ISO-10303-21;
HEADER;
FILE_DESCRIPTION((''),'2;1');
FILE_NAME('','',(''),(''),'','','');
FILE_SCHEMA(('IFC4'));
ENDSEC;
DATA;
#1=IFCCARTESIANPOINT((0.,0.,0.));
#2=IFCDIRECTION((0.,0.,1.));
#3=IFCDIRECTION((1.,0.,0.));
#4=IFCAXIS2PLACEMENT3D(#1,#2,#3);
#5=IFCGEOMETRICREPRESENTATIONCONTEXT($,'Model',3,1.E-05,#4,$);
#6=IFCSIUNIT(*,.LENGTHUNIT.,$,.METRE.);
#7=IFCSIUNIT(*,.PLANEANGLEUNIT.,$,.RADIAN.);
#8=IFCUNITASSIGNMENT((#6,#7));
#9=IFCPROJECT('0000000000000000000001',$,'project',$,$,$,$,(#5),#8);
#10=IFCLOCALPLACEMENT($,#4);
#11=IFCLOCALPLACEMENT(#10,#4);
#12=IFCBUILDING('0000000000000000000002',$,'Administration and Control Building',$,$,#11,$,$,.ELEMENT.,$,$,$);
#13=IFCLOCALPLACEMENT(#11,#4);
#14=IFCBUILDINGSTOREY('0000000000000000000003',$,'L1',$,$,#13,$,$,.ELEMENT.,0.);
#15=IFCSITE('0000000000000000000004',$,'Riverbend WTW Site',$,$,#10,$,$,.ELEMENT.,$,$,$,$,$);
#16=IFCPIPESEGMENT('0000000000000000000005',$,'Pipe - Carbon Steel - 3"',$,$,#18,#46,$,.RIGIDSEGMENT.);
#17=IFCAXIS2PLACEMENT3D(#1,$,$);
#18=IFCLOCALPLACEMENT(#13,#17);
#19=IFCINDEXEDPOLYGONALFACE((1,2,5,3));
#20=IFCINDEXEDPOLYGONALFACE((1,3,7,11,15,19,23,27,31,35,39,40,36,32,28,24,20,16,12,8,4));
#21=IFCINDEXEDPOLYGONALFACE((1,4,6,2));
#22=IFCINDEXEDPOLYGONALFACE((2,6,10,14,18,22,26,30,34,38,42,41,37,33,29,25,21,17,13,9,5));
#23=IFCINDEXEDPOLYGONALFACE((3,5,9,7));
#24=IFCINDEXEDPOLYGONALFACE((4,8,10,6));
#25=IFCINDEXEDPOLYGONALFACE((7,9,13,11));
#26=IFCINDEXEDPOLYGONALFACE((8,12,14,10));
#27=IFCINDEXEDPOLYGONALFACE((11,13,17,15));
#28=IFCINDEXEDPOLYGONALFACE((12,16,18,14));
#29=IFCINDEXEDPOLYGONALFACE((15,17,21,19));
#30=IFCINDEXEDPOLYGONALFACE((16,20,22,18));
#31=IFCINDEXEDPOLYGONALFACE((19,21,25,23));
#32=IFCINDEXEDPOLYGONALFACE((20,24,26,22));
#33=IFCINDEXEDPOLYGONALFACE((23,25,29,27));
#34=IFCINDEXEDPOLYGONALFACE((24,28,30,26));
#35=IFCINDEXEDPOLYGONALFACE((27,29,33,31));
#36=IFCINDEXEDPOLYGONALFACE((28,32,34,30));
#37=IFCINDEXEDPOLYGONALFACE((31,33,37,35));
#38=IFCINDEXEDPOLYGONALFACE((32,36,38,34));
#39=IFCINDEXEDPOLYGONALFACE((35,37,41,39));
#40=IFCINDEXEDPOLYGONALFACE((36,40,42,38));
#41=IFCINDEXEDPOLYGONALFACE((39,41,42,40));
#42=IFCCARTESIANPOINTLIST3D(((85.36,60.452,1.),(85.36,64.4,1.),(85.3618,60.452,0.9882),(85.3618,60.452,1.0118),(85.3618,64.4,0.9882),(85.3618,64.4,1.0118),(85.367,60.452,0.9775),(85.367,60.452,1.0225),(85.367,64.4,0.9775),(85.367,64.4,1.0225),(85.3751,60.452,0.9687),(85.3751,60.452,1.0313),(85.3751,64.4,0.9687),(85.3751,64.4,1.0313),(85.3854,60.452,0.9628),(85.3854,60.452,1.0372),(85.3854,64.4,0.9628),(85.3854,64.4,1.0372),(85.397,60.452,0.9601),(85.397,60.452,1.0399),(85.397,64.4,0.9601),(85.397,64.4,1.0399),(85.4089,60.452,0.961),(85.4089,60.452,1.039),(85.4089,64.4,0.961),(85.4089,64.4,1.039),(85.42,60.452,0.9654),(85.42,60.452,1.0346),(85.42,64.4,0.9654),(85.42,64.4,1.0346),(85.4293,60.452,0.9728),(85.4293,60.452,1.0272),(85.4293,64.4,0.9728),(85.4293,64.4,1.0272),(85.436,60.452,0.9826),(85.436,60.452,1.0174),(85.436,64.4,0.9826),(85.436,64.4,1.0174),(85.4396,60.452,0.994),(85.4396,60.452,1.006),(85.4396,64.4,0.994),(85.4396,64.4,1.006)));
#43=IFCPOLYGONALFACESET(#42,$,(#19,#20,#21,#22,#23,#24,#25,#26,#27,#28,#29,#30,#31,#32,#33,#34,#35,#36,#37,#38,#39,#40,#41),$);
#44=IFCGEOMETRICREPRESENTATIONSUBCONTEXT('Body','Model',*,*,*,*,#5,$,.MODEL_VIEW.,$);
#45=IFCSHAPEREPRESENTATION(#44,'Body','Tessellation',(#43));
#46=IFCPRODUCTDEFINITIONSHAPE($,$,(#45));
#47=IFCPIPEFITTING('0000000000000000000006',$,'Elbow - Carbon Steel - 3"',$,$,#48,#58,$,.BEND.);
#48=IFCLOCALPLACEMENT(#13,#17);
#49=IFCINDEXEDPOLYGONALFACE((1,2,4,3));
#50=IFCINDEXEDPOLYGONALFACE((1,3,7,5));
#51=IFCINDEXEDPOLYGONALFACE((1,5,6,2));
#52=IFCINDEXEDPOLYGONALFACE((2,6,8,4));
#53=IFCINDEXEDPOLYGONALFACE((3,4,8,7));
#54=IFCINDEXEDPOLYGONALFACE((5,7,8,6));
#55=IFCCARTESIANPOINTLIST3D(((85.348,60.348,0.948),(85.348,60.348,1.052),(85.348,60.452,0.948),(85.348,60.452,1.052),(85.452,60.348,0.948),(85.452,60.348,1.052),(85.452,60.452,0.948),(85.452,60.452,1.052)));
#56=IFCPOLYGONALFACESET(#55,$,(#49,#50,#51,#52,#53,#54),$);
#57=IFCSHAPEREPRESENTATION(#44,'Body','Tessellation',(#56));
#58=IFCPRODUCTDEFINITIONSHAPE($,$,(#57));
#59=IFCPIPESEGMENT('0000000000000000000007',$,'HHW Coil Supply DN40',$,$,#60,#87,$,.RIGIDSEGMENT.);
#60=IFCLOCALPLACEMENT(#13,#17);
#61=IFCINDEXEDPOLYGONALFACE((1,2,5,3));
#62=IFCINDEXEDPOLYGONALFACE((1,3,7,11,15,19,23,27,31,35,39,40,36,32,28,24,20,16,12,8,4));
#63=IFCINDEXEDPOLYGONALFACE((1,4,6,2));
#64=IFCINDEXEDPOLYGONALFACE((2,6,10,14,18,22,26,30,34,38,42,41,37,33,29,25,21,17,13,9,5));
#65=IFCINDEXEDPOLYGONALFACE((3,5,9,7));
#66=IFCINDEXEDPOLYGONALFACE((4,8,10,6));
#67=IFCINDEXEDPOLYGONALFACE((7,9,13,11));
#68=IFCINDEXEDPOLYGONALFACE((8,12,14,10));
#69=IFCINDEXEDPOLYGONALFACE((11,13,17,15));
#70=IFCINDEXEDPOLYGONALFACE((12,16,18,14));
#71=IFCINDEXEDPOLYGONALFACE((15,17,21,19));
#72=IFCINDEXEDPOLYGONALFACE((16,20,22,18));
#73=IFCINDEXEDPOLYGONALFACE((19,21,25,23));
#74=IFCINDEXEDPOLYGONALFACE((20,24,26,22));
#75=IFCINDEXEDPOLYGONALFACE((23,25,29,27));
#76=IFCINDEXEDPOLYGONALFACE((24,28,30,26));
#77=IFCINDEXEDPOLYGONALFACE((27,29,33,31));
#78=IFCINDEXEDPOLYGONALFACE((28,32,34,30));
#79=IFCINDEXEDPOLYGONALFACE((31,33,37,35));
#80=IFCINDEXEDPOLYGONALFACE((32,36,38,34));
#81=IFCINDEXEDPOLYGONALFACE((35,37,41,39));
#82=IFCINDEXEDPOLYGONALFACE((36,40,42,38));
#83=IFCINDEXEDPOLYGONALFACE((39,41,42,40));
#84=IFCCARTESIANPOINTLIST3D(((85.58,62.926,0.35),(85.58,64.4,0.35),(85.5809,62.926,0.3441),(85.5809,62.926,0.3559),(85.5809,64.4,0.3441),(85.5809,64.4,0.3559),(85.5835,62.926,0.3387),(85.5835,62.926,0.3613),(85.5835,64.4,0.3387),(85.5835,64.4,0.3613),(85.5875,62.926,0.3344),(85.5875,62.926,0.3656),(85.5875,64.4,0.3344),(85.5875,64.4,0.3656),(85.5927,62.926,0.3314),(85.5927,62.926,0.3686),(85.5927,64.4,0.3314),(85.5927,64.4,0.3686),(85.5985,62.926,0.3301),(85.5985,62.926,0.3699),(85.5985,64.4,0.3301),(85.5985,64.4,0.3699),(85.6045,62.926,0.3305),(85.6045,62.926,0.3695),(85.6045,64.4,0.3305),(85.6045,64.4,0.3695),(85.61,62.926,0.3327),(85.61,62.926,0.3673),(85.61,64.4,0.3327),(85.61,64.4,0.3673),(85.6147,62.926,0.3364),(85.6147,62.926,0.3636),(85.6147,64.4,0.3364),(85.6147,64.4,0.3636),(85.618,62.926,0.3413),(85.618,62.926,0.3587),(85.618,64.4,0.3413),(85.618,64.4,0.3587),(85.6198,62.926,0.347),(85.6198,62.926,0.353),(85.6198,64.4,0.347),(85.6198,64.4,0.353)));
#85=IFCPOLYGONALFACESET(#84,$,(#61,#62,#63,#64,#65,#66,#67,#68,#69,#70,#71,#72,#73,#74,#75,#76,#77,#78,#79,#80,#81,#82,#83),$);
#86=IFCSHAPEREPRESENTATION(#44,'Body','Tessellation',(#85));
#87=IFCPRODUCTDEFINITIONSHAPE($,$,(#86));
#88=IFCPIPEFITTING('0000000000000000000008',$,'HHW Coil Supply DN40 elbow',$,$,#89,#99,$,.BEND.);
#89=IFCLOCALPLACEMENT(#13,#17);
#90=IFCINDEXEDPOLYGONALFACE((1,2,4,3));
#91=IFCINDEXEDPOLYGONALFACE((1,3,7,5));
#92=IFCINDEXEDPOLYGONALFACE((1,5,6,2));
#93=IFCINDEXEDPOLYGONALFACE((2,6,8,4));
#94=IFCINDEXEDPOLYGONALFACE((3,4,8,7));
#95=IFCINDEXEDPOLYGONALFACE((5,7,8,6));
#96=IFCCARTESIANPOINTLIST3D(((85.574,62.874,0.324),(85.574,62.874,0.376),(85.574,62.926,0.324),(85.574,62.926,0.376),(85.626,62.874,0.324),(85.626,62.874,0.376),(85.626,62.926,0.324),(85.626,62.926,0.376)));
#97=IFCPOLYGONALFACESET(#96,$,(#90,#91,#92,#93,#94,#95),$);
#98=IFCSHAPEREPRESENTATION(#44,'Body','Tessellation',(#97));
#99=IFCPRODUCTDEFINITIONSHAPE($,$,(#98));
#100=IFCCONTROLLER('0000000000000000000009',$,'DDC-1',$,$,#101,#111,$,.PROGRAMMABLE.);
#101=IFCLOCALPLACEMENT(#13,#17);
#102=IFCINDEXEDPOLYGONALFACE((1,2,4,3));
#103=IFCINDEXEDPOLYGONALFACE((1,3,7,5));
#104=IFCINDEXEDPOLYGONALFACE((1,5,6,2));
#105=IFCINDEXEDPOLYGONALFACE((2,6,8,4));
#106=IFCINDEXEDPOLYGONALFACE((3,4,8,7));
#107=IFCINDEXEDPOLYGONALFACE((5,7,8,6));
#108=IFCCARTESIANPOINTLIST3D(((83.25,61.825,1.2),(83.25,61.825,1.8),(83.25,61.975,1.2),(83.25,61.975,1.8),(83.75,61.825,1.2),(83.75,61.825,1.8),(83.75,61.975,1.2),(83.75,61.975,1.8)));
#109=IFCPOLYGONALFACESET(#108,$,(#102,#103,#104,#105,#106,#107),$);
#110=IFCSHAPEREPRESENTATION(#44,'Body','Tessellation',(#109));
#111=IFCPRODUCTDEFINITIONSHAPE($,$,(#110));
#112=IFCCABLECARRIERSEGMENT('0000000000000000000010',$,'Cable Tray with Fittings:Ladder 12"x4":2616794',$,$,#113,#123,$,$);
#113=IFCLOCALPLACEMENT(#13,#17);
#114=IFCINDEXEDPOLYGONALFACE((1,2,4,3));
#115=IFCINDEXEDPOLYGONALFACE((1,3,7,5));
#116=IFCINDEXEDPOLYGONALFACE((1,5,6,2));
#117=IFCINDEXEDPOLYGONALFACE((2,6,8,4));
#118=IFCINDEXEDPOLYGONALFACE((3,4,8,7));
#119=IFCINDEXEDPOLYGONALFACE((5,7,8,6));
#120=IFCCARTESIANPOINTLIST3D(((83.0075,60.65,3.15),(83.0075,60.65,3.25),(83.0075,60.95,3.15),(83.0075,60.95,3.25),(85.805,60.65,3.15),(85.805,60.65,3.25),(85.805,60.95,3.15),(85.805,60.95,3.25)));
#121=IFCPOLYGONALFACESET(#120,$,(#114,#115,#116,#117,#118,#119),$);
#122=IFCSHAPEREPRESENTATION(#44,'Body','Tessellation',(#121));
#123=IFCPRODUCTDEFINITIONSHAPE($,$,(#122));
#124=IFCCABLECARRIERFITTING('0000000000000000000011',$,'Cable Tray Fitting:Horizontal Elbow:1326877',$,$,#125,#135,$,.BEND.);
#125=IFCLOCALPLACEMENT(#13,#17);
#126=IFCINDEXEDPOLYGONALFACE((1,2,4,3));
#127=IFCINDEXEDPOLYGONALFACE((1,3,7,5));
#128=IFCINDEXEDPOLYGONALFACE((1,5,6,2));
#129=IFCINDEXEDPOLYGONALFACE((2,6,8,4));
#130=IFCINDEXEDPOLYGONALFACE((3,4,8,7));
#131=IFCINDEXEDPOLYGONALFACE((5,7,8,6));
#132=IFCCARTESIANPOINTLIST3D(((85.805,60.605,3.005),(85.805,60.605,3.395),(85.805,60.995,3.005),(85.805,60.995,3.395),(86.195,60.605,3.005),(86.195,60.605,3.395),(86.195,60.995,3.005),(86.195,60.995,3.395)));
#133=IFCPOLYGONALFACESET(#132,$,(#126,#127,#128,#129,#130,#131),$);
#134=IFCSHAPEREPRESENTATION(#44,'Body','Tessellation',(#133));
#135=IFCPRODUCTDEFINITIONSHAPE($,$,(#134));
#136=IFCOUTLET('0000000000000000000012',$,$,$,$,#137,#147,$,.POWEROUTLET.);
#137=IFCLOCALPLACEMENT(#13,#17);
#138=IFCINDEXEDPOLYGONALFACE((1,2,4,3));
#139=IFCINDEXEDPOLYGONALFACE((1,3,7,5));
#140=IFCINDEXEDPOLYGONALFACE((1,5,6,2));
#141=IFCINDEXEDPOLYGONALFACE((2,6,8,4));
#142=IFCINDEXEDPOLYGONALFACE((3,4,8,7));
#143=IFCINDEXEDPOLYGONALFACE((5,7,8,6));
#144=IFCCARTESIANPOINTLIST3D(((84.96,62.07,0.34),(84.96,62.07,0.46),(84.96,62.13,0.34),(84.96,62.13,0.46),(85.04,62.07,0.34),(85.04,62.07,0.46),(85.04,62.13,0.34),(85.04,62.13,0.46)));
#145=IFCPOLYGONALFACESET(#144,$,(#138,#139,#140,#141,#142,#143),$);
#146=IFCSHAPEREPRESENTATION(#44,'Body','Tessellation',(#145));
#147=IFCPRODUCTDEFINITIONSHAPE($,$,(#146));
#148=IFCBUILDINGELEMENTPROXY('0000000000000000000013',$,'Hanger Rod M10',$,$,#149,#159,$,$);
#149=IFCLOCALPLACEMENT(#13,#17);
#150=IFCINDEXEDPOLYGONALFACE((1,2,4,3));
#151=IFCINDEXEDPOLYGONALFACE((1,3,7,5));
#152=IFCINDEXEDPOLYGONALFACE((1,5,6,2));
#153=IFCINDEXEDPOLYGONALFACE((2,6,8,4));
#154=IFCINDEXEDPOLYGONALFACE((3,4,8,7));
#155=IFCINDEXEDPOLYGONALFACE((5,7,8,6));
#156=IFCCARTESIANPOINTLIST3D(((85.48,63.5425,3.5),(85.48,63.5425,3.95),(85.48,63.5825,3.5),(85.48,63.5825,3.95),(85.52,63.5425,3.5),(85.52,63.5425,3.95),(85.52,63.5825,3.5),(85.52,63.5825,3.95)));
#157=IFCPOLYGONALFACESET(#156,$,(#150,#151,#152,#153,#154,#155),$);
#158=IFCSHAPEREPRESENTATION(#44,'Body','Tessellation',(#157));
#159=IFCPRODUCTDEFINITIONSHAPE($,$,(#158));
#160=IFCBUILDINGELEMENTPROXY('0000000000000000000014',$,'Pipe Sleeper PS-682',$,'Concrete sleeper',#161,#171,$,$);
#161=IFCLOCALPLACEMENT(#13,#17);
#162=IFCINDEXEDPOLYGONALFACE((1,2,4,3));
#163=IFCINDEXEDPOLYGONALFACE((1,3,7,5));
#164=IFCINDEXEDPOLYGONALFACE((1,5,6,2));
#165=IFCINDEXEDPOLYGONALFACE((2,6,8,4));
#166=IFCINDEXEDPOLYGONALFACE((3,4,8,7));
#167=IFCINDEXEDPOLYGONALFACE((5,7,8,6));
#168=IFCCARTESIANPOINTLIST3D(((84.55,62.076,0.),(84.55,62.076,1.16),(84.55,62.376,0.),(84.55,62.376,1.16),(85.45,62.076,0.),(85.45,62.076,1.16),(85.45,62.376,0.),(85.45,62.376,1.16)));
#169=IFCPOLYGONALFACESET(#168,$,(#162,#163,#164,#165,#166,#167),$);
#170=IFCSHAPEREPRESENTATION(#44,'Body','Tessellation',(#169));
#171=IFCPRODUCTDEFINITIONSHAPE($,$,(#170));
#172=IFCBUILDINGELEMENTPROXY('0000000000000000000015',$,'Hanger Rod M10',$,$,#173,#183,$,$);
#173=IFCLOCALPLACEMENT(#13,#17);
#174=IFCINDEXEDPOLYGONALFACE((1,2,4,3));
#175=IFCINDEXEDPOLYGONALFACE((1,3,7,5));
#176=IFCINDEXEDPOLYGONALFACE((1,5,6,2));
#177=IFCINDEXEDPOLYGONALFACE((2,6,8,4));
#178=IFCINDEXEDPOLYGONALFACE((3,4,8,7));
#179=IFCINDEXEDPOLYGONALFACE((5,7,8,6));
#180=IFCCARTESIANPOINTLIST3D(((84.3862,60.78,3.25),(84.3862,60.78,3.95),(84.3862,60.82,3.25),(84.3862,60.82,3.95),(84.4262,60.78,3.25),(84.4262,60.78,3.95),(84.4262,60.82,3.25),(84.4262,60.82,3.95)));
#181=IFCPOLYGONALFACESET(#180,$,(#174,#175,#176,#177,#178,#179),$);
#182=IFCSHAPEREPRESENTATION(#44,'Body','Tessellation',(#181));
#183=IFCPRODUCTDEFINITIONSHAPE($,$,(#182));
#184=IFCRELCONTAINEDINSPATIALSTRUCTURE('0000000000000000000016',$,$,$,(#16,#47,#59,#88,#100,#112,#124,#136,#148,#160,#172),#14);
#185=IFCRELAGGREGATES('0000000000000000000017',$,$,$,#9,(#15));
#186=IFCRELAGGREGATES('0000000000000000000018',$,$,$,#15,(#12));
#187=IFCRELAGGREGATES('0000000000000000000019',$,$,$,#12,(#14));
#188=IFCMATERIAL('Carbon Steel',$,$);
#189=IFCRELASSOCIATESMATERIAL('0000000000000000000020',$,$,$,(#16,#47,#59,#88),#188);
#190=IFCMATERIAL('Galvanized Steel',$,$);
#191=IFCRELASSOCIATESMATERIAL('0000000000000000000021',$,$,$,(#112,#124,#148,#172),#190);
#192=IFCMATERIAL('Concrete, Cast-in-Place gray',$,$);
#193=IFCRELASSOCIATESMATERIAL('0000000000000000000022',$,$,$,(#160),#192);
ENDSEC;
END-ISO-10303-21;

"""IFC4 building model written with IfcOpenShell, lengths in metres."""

from ifc_helpers import new_model, si_unit, frame, origin_with_axes, origin_2d, place, context, subcontext, project, spatial, rectangle, circle, extrude, material, element, save


model = new_model("IFC4")

# Units and contexts
model_context = context("Model", 3, precision=1e-05, world=origin_with_axes())
body_context = subcontext(model_context, "Body", "Model", "MODEL_VIEW")
ifc_project = project(units=[si_unit("LENGTHUNIT", "METRE"), si_unit("PLANEANGLEUNIT", "RADIAN")], contexts=[model_context])

# Site, building, storey
site_placement = place(None, origin_with_axes())
site = spatial("IfcSite", under=ifc_project, at=site_placement, Name="Riverbend WTW Site", CompositionType="ELEMENT")
building_placement = place(site_placement, origin_with_axes())
building = spatial("IfcBuilding", under=site, at=building_placement, Name="Administration and Control Building", CompositionType="ELEMENT")
storey_placement = place(building_placement, origin_with_axes())
storey = spatial("IfcBuildingStorey", under=building, at=storey_placement, Name="L1", CompositionType="ELEMENT", Elevation=0.0)

# Shared definitions
ifc_material_1 = material(Name="Concrete, Cast-in-Place gray")

# Shared definitions
ifc_material_2 = material(Name="Galvanized Steel")

# Pipe segment
ifc_material_3 = material(Name="Carbon Steel")
pipe_segment_1_placement = place(None, frame((85.4, 60.452, 1.0), z_axis=(0.0, 0.0, 1.0), x_axis=(1.0, 0.0, 0.0)))
element("IfcPipeSegment", 1, at=pipe_segment_1_placement, inside=storey, material=ifc_material_3, Name="Pipe - Carbon Steel - 3\"", PredefinedType="RIGIDSEGMENT", context=body_context, shape_type="SweptSolid", body=[
    extrude(circle(Radius=0.04, at=origin_2d()), frame((0.0, 0.0, 0.0), z_axis=(0.0, 1.0, 0.0), x_axis=(-1.0, 0.0, 0.0)), (0.0, 0.0, 1.0), 3.948),
])

# Pipe fitting
pipe_fitting_1_placement = place(None, frame((85.4, 60.4, 1.0), z_axis=(0.0, 0.0, 1.0), x_axis=(1.0, 0.0, 0.0)))
element("IfcPipeFitting", 2, at=pipe_fitting_1_placement, inside=storey, material=ifc_material_3, Name="Elbow - Carbon Steel - 3\"", PredefinedType="BEND", context=body_context, shape_type="SweptSolid", body=[
    extrude(rectangle(XDim=0.104, YDim=0.104, at=origin_2d()), frame((0.0, 0.0, -0.052), z_axis=(0.0, 0.0, 1.0), x_axis=(1.0, 0.0, 0.0)), (0.0, 0.0, 1.0), 0.104),
])

# Pipe segment
pipe_segment_2_placement = place(None, frame((85.6, 62.926, 0.35), z_axis=(0.0, 0.0, 1.0), x_axis=(1.0, 0.0, 0.0)))
element("IfcPipeSegment", 3, at=pipe_segment_2_placement, inside=storey, material=ifc_material_3, Name="HHW Coil Supply DN40", PredefinedType="RIGIDSEGMENT", context=body_context, shape_type="SweptSolid", body=[
    extrude(circle(Radius=0.02, at=origin_2d()), frame((0.0, 0.0, 0.0), z_axis=(0.0, 1.0, 0.0), x_axis=(-1.0, 0.0, 0.0)), (0.0, 0.0, 1.0), 1.474),
])

# Pipe fitting
pipe_fitting_2_placement = place(None, frame((85.6, 62.9, 0.35), z_axis=(0.0, 0.0, 1.0), x_axis=(1.0, 0.0, 0.0)))
element("IfcPipeFitting", 4, at=pipe_fitting_2_placement, inside=storey, material=ifc_material_3, Name="HHW Coil Supply DN40 elbow", PredefinedType="BEND", context=body_context, shape_type="SweptSolid", body=[
    extrude(rectangle(XDim=0.052, YDim=0.052, at=origin_2d()), frame((0.0, 0.0, -0.026), z_axis=(0.0, 0.0, 1.0), x_axis=(1.0, 0.0, 0.0)), (0.0, 0.0, 1.0), 0.052),
])

# Controller
controller_placement = place(None, frame((83.5, 61.9, 1.5), z_axis=(0.0, 0.0, 1.0), x_axis=(1.0, 0.0, 0.0)))
element("IfcController", 5, at=controller_placement, inside=storey, Name="DDC-1", PredefinedType="PROGRAMMABLE", context=body_context, shape_type="SweptSolid", body=[
    extrude(rectangle(XDim=0.5, YDim=0.15, at=origin_2d()), frame((0.0, 0.0, -0.3), z_axis=(0.0, 0.0, 1.0), x_axis=(1.0, 0.0, 0.0)), (0.0, 0.0, 1.0), 0.6),
])

# Cable carrier segment
cable_carrier_segment_placement = place(None, frame((84.4062, 60.8, 3.2), z_axis=(0.0, 0.0, 1.0), x_axis=(1.0, 0.0, 0.0)))
element("IfcCableCarrierSegment", 6, at=cable_carrier_segment_placement, inside=storey, material=ifc_material_2, Name="Cable Tray with Fittings:Ladder 12\"x4\":2616794", context=body_context, shape_type="SweptSolid", body=[
    extrude(rectangle(XDim=2.7975, YDim=0.3, at=origin_2d()), frame((0.0, 0.0, -0.05), z_axis=(0.0, 0.0, 1.0), x_axis=(1.0, 0.0, 0.0)), (0.0, 0.0, 1.0), 0.1),
])

# Cable carrier fitting
cable_carrier_fitting_placement = place(None, frame((86.0, 60.8, 3.2), z_axis=(0.0, 0.0, 1.0), x_axis=(1.0, 0.0, 0.0)))
element("IfcCableCarrierFitting", 7, at=cable_carrier_fitting_placement, inside=storey, material=ifc_material_2, Name="Cable Tray Fitting:Horizontal Elbow:1326877", PredefinedType="BEND", context=body_context, shape_type="SweptSolid", body=[
    extrude(rectangle(XDim=0.39, YDim=0.39, at=origin_2d()), frame((0.0, 0.0, -0.195), z_axis=(0.0, 0.0, 1.0), x_axis=(1.0, 0.0, 0.0)), (0.0, 0.0, 1.0), 0.39),
])

# Outlet
outlet_placement = place(None, frame((85.0, 62.1, 0.4), z_axis=(0.0, 0.0, 1.0), x_axis=(1.0, 0.0, 0.0)))
element("IfcOutlet", 8, at=outlet_placement, inside=storey, PredefinedType="POWEROUTLET", context=body_context, shape_type="SweptSolid", body=[
    extrude(rectangle(XDim=0.08, YDim=0.06, at=origin_2d()), frame((0.0, 0.0, -0.06), z_axis=(0.0, 0.0, 1.0), x_axis=(1.0, 0.0, 0.0)), (0.0, 0.0, 1.0), 0.12),
])

# Building element proxies
proxy_1_placement = place(None, frame((85.5, 63.5625, 3.725), z_axis=(0.0, 0.0, 1.0), x_axis=(1.0, 0.0, 0.0)))
element("IfcBuildingElementProxy", 9, at=proxy_1_placement, inside=storey, material=ifc_material_2, Name="Hanger Rod M10", context=body_context, shape_type="SweptSolid", body=[
    extrude(rectangle(XDim=0.04, YDim=0.04, at=origin_2d()), frame((0.0, 0.0, -0.225), z_axis=(0.0, 0.0, 1.0), x_axis=(1.0, 0.0, 0.0)), (0.0, 0.0, 1.0), 0.45),
])
proxy_2_placement = place(None, frame((85.0, 62.226, 0.58), z_axis=(0.0, 0.0, 1.0), x_axis=(1.0, 0.0, 0.0)))
element("IfcBuildingElementProxy", 10, at=proxy_2_placement, inside=storey, material=ifc_material_1, Name="Pipe Sleeper PS-682", ObjectType="Concrete sleeper", context=body_context, shape_type="SweptSolid", body=[
    extrude(rectangle(XDim=0.9, YDim=0.3, at=origin_2d()), frame((0.0, 0.0, -0.58), z_axis=(0.0, 0.0, 1.0), x_axis=(1.0, 0.0, 0.0)), (0.0, 0.0, 1.0), 1.16),
])
proxy_3_placement = place(None, frame((84.4062, 60.8, 3.6), z_axis=(0.0, 0.0, 1.0), x_axis=(1.0, 0.0, 0.0)))
element("IfcBuildingElementProxy", 11, at=proxy_3_placement, inside=storey, material=ifc_material_2, Name="Hanger Rod M10", context=body_context, shape_type="SweptSolid", body=[
    extrude(rectangle(XDim=0.04, YDim=0.04, at=origin_2d()), frame((0.0, 0.0, -0.35), z_axis=(0.0, 0.0, 1.0), x_axis=(1.0, 0.0, 0.0)), (0.0, 0.0, 1.0), 0.7),
])

save(model, "model.ifc")
